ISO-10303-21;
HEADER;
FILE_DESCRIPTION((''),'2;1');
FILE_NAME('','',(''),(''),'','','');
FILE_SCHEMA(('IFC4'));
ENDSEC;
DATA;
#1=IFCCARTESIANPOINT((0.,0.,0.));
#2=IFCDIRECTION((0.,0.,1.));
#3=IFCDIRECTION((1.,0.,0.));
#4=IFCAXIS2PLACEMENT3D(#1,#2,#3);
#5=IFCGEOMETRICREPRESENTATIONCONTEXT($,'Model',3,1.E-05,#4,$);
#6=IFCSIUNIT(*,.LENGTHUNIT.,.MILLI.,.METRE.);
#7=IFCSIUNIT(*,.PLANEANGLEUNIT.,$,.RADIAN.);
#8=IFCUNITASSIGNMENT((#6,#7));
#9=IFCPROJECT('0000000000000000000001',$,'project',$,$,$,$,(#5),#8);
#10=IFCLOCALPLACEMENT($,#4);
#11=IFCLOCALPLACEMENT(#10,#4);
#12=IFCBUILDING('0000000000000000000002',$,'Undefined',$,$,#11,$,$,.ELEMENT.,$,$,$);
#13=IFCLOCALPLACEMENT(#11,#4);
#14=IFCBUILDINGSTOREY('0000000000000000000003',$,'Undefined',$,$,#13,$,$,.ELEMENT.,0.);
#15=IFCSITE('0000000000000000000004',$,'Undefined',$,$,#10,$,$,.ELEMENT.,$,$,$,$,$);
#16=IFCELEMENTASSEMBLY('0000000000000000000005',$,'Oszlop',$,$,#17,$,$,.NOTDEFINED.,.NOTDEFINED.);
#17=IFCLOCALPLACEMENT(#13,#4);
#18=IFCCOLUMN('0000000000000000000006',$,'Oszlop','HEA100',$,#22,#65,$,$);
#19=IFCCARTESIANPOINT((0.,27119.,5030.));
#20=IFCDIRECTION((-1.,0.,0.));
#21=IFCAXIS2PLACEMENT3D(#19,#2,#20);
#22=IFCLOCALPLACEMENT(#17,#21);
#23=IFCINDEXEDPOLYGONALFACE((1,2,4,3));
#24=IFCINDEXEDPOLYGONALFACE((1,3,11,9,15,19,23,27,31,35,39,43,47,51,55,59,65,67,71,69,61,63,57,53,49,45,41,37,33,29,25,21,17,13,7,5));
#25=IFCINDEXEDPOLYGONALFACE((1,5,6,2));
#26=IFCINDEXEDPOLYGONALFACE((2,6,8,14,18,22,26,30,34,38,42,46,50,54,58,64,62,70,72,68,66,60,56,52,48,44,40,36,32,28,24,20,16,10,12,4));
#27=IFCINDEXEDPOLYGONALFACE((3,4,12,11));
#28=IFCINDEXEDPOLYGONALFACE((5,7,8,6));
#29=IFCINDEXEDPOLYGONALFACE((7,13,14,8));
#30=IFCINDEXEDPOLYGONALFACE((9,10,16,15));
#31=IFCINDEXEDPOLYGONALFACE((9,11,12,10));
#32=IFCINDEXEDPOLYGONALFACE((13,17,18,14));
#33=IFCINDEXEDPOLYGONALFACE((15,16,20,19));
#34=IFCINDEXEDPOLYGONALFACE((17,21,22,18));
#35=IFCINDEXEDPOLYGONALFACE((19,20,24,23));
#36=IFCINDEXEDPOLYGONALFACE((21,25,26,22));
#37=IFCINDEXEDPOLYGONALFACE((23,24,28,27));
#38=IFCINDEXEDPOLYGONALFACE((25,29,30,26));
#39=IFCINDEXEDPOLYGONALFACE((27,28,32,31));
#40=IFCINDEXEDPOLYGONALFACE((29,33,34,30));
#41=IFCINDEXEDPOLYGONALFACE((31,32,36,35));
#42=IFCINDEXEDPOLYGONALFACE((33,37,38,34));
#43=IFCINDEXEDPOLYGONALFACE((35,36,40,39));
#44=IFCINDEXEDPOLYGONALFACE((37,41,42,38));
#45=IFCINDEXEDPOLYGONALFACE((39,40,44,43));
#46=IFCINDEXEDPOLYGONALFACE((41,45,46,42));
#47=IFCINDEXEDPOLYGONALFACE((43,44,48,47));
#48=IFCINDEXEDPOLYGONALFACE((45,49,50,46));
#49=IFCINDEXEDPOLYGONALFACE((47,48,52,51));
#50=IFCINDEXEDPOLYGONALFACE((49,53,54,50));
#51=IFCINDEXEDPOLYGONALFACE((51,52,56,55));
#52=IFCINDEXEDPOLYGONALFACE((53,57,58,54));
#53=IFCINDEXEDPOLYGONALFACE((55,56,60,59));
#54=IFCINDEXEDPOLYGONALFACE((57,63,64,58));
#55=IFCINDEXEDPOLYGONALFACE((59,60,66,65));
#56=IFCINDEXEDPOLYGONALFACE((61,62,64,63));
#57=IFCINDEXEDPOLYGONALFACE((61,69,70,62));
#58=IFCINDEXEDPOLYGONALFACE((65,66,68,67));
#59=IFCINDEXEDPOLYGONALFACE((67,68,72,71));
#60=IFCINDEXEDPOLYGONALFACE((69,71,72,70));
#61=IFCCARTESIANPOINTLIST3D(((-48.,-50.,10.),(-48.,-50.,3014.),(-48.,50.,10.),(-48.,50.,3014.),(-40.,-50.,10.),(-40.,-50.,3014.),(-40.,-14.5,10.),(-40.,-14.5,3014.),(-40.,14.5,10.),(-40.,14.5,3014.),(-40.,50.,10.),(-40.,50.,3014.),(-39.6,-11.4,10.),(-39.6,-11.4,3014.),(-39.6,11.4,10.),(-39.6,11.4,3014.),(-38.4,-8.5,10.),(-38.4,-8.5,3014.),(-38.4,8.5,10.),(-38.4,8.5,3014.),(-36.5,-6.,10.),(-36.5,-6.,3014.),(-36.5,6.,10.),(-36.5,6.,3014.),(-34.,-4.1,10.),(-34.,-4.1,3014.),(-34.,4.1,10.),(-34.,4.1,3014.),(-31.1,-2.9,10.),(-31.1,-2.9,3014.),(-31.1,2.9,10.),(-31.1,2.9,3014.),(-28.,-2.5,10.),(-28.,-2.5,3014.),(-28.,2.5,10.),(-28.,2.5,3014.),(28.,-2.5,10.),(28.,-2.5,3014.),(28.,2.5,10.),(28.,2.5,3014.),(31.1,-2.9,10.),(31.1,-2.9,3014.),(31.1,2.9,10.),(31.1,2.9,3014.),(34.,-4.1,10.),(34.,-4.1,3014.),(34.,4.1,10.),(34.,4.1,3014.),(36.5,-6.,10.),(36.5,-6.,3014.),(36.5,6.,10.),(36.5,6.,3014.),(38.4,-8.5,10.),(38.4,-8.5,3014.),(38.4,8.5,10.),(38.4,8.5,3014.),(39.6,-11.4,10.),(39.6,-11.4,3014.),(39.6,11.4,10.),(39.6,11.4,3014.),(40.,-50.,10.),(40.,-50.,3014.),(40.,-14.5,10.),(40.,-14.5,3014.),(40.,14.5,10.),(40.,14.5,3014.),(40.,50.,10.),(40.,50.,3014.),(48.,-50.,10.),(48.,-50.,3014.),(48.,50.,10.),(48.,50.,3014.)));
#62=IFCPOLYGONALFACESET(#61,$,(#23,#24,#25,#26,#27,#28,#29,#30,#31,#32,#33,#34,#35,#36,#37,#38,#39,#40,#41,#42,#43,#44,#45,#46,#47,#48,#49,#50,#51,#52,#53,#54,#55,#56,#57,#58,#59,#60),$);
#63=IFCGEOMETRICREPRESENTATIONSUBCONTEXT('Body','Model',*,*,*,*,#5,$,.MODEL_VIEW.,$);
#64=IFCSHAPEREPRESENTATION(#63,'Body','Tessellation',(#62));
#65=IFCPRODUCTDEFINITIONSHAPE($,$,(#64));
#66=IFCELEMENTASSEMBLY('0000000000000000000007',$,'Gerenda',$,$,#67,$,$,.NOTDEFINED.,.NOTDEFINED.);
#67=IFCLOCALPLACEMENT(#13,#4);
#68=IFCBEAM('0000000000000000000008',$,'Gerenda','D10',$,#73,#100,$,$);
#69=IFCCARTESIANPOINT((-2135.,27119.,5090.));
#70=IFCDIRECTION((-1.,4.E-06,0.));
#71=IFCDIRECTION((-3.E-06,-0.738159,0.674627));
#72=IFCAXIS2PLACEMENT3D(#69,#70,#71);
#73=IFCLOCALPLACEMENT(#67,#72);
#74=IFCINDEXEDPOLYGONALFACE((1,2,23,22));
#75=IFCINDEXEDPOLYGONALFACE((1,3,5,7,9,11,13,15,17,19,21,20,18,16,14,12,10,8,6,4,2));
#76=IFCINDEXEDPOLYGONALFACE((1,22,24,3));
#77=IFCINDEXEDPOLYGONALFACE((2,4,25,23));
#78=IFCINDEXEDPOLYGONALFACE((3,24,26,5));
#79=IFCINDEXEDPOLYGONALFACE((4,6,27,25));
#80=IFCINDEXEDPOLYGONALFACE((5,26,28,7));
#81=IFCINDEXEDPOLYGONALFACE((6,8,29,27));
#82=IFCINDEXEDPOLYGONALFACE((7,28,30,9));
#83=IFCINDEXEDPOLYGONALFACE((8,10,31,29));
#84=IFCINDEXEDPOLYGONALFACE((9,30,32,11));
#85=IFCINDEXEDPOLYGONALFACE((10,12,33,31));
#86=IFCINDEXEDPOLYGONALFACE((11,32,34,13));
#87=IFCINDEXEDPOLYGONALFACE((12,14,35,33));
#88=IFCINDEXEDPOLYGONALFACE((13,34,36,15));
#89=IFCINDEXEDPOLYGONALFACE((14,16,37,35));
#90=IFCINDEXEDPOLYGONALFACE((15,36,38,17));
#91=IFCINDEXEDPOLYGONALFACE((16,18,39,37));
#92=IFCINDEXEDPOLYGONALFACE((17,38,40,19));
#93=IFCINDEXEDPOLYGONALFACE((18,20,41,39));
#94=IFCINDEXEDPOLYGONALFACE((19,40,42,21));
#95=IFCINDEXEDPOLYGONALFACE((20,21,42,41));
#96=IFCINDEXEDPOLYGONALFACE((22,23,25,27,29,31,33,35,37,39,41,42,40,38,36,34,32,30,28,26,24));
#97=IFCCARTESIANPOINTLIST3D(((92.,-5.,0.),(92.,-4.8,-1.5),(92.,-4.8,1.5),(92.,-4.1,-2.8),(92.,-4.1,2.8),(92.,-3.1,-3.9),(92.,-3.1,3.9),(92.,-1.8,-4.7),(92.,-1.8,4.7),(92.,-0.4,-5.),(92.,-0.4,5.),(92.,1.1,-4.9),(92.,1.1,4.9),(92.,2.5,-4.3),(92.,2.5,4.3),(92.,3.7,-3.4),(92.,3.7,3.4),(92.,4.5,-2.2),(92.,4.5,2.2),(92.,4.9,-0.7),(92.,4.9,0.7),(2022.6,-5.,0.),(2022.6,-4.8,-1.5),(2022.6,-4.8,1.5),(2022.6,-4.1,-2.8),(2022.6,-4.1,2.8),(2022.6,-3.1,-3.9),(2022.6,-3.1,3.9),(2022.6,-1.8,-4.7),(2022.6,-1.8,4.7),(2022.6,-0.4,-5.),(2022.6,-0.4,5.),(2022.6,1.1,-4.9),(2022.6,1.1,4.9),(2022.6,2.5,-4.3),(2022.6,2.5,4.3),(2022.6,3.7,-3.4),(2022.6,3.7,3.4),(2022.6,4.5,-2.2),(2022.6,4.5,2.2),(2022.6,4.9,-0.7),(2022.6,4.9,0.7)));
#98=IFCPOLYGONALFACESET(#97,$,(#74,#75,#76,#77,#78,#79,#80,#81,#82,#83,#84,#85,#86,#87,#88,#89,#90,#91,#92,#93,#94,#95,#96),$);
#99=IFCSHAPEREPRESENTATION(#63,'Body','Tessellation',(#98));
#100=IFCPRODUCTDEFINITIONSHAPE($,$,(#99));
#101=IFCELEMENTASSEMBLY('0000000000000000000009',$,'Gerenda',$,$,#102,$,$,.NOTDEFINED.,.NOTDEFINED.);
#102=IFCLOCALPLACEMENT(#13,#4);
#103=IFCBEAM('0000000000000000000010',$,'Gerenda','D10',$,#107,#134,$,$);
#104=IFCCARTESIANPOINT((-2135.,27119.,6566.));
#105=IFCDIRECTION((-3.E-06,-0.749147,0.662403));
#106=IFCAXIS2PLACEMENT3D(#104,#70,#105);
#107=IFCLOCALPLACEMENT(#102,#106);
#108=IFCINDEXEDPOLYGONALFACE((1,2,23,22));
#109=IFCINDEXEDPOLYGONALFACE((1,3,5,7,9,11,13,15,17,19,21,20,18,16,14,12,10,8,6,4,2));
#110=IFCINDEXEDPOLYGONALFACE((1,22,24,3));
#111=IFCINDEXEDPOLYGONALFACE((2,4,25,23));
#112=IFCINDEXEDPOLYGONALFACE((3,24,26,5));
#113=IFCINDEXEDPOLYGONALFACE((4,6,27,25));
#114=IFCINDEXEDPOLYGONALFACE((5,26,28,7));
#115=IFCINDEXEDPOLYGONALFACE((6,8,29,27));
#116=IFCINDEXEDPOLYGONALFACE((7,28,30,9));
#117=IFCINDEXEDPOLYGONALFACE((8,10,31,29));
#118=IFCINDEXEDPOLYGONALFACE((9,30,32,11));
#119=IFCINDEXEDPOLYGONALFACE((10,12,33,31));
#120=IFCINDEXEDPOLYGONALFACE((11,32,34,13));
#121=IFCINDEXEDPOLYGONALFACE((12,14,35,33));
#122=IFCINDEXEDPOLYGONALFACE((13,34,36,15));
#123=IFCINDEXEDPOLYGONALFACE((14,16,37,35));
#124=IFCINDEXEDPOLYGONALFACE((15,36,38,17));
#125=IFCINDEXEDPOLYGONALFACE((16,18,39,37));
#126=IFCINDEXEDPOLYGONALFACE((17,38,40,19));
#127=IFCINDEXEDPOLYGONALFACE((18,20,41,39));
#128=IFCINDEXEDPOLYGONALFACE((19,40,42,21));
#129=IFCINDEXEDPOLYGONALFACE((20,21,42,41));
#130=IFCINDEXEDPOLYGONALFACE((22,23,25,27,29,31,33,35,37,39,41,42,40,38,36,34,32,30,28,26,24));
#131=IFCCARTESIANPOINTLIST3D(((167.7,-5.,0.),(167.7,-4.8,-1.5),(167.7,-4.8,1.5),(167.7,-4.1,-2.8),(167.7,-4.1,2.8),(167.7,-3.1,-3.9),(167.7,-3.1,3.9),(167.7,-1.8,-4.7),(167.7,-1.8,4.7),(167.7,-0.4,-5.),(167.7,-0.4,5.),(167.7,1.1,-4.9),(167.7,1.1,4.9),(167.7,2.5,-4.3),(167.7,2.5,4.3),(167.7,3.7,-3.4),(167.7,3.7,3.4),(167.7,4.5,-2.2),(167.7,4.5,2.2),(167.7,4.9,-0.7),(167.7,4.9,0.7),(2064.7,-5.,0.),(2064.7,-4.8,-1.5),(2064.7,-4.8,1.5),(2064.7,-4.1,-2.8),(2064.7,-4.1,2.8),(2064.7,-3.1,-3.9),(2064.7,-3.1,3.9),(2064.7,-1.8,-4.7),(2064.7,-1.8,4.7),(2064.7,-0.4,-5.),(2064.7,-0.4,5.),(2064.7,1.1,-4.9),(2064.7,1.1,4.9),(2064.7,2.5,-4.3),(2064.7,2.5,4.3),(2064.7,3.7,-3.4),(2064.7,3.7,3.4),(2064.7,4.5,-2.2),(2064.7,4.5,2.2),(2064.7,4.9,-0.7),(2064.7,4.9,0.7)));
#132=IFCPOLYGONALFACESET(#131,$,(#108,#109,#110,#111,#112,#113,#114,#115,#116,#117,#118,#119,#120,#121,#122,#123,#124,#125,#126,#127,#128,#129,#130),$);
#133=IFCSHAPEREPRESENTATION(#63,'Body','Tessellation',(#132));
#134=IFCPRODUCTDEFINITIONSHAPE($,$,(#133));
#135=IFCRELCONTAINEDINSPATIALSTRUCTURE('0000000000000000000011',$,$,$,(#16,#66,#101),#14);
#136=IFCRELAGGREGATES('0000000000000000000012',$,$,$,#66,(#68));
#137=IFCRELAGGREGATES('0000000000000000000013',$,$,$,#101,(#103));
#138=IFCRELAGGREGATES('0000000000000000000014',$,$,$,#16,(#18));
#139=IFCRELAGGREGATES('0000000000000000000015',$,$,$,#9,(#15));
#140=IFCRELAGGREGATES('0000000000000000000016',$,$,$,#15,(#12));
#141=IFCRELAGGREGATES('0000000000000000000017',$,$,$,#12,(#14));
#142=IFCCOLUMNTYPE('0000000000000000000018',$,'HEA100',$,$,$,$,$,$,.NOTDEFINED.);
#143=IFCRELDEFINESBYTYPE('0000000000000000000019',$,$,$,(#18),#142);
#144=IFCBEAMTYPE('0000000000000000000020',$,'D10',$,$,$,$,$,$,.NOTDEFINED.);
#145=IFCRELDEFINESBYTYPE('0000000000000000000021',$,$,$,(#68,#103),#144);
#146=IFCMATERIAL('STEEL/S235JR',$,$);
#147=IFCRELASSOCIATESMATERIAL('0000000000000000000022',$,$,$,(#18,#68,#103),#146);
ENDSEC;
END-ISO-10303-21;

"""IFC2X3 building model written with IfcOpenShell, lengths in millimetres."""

from ifc_helpers import new_model, si_unit, frame, origin_with_axes, origin_2d_with_axis, place, context, subcontext, project, spatial, circle, i_section, extrude, clip, halfspace, material, type_object, element, aggregate, save


model = new_model("IFC2X3")

# Units and contexts
model_context = context("Model", 3, precision=1e-05, world=origin_with_axes())
body_context = subcontext(model_context, "Body", "Model", "MODEL_VIEW")
ifc_project = project(units=[si_unit("LENGTHUNIT", "METRE", prefix="MILLI"), si_unit("PLANEANGLEUNIT", "RADIAN")], contexts=[model_context])

# Site, building, storey
site_placement = place(None, origin_with_axes())
site = spatial("IfcSite", under=ifc_project, at=site_placement, Name="Undefined", CompositionType="ELEMENT")
building_placement = place(site_placement, origin_with_axes())
building = spatial("IfcBuilding", under=site, at=building_placement, Name="Undefined", CompositionType="ELEMENT")
storey_placement = place(building_placement, origin_with_axes())
storey = spatial("IfcBuildingStorey", under=building, at=storey_placement, Name="Undefined", CompositionType="ELEMENT", Elevation=0.0)

# Element assembly, column
ifc_material_1 = material(Name="STEEL/S235JR")
column_type = type_object("IfcColumnType", Name="HEA100", PredefinedType="NOTDEFINED")
assembly_1_placement = place(storey_placement, origin_with_axes())
assembly_1 = element("IfcElementAssembly", 1, at=assembly_1_placement, inside=storey, Name="Oszlop", AssemblyPlace="NOTDEFINED", PredefinedType="NOTDEFINED")
column_1_placement = place(assembly_1_placement, frame((0.0, 27119.0, 5030.0), z_axis=(0.0, 0.0, 1.0), x_axis=(-1.0, 0.0, 0.0)))
column_1 = element("IfcColumn", 2, at=column_1_placement, type_object=column_type, material=ifc_material_1, Name="Oszlop", Description="HEA100", context=body_context, shape_type="Clipping", body=[
    clip(clip(extrude(i_section(OverallWidth=100.0, OverallDepth=96.0, WebThickness=5.0, FlangeThickness=8.0, FilletRadius=12.0, at=origin_2d_with_axis()), frame((0.0, 0.0, 3024.0), z_axis=(0.0, 0.0, -1.0), x_axis=(0.0, 1.0, 0.0)), (0.0, 0.0, 1.0), 3024.0), halfspace(frame((-48.0, 0.0, 3014.0), z_axis=(0.0, 0.0, -1.0), x_axis=(0.0, -1.0, 0.0)), True)), halfspace(frame((-48.0, 0.0, 10.0), z_axis=(0.0, 0.0, 1.0), x_axis=(0.0, 1.0, 0.0)), True)),
])

# Element assemblies, beams
assembly_2_placement = place(storey_placement, origin_with_axes())
assembly_2 = element("IfcElementAssembly", 3, at=assembly_2_placement, inside=storey, Name="Gerenda", AssemblyPlace="NOTDEFINED", PredefinedType="NOTDEFINED")
beam_type = type_object("IfcBeamType", Name="D10", PredefinedType="NOTDEFINED")
beam_1_placement = place(assembly_2_placement, frame((-2135.0, 27119.0, 5090.0), z_axis=(-1.0, 0.000004, 0.0), x_axis=(-0.000003, -0.738159, 0.674627)))
beam_1 = element("IfcBeam", 4, at=beam_1_placement, type_object=beam_type, material=ifc_material_1, Name="Gerenda", Description="D10", context=body_context, shape_type="Clipping", body=[
    clip(clip(extrude(circle(Radius=5.0, at=origin_2d_with_axis()), frame((2187.9, 0.0, 0.0), z_axis=(-1.0, 0.0, 0.0), x_axis=(0.0, -1.0, 0.0)), (0.0, 0.0, 1.0), 2187.9), halfspace(frame((2022.6, 0.0, -7.5), z_axis=(-1.0, 0.0, 0.0), x_axis=(0.0, 1.0, 0.000003)), True)), halfspace(frame((92.0, 0.0, -7.5), z_axis=(1.0, 0.0, 0.0), x_axis=(0.0, -1.0, -0.000006)), True)),
])
aggregate(assembly_2, [beam_1])
assembly_3_placement = place(storey_placement, origin_with_axes())
assembly_3 = element("IfcElementAssembly", 5, at=assembly_3_placement, inside=storey, Name="Gerenda", AssemblyPlace="NOTDEFINED", PredefinedType="NOTDEFINED")
beam_2_placement = place(assembly_3_placement, frame((-2135.0, 27119.0, 6566.0), z_axis=(-1.0, 0.000004, 0.0), x_axis=(-0.000003, -0.749147, 0.662403)))
beam_2 = element("IfcBeam", 6, at=beam_2_placement, type_object=beam_type, material=ifc_material_1, Name="Gerenda", Description="D10", context=body_context, shape_type="Clipping", body=[
    clip(clip(extrude(circle(Radius=5.0, at=origin_2d_with_axis()), frame((2155.8, 0.0, 0.0), z_axis=(-1.0, 0.0, 0.0), x_axis=(0.0, -1.0, 0.0)), (0.0, 0.0, 1.0), 2155.8), halfspace(frame((2064.7, 0.0, -7.5), z_axis=(-1.0, 0.0, 0.0), x_axis=(0.0, 1.0, 0.000006)), True)), halfspace(frame((167.7, 0.0, -7.5), z_axis=(1.0, 0.0, 0.0), x_axis=(0.0, -1.0, -0.000003)), True)),
])
aggregate(assembly_3, [beam_2])

aggregate(assembly_1, [column_1])

save(model, "model.ifc")
